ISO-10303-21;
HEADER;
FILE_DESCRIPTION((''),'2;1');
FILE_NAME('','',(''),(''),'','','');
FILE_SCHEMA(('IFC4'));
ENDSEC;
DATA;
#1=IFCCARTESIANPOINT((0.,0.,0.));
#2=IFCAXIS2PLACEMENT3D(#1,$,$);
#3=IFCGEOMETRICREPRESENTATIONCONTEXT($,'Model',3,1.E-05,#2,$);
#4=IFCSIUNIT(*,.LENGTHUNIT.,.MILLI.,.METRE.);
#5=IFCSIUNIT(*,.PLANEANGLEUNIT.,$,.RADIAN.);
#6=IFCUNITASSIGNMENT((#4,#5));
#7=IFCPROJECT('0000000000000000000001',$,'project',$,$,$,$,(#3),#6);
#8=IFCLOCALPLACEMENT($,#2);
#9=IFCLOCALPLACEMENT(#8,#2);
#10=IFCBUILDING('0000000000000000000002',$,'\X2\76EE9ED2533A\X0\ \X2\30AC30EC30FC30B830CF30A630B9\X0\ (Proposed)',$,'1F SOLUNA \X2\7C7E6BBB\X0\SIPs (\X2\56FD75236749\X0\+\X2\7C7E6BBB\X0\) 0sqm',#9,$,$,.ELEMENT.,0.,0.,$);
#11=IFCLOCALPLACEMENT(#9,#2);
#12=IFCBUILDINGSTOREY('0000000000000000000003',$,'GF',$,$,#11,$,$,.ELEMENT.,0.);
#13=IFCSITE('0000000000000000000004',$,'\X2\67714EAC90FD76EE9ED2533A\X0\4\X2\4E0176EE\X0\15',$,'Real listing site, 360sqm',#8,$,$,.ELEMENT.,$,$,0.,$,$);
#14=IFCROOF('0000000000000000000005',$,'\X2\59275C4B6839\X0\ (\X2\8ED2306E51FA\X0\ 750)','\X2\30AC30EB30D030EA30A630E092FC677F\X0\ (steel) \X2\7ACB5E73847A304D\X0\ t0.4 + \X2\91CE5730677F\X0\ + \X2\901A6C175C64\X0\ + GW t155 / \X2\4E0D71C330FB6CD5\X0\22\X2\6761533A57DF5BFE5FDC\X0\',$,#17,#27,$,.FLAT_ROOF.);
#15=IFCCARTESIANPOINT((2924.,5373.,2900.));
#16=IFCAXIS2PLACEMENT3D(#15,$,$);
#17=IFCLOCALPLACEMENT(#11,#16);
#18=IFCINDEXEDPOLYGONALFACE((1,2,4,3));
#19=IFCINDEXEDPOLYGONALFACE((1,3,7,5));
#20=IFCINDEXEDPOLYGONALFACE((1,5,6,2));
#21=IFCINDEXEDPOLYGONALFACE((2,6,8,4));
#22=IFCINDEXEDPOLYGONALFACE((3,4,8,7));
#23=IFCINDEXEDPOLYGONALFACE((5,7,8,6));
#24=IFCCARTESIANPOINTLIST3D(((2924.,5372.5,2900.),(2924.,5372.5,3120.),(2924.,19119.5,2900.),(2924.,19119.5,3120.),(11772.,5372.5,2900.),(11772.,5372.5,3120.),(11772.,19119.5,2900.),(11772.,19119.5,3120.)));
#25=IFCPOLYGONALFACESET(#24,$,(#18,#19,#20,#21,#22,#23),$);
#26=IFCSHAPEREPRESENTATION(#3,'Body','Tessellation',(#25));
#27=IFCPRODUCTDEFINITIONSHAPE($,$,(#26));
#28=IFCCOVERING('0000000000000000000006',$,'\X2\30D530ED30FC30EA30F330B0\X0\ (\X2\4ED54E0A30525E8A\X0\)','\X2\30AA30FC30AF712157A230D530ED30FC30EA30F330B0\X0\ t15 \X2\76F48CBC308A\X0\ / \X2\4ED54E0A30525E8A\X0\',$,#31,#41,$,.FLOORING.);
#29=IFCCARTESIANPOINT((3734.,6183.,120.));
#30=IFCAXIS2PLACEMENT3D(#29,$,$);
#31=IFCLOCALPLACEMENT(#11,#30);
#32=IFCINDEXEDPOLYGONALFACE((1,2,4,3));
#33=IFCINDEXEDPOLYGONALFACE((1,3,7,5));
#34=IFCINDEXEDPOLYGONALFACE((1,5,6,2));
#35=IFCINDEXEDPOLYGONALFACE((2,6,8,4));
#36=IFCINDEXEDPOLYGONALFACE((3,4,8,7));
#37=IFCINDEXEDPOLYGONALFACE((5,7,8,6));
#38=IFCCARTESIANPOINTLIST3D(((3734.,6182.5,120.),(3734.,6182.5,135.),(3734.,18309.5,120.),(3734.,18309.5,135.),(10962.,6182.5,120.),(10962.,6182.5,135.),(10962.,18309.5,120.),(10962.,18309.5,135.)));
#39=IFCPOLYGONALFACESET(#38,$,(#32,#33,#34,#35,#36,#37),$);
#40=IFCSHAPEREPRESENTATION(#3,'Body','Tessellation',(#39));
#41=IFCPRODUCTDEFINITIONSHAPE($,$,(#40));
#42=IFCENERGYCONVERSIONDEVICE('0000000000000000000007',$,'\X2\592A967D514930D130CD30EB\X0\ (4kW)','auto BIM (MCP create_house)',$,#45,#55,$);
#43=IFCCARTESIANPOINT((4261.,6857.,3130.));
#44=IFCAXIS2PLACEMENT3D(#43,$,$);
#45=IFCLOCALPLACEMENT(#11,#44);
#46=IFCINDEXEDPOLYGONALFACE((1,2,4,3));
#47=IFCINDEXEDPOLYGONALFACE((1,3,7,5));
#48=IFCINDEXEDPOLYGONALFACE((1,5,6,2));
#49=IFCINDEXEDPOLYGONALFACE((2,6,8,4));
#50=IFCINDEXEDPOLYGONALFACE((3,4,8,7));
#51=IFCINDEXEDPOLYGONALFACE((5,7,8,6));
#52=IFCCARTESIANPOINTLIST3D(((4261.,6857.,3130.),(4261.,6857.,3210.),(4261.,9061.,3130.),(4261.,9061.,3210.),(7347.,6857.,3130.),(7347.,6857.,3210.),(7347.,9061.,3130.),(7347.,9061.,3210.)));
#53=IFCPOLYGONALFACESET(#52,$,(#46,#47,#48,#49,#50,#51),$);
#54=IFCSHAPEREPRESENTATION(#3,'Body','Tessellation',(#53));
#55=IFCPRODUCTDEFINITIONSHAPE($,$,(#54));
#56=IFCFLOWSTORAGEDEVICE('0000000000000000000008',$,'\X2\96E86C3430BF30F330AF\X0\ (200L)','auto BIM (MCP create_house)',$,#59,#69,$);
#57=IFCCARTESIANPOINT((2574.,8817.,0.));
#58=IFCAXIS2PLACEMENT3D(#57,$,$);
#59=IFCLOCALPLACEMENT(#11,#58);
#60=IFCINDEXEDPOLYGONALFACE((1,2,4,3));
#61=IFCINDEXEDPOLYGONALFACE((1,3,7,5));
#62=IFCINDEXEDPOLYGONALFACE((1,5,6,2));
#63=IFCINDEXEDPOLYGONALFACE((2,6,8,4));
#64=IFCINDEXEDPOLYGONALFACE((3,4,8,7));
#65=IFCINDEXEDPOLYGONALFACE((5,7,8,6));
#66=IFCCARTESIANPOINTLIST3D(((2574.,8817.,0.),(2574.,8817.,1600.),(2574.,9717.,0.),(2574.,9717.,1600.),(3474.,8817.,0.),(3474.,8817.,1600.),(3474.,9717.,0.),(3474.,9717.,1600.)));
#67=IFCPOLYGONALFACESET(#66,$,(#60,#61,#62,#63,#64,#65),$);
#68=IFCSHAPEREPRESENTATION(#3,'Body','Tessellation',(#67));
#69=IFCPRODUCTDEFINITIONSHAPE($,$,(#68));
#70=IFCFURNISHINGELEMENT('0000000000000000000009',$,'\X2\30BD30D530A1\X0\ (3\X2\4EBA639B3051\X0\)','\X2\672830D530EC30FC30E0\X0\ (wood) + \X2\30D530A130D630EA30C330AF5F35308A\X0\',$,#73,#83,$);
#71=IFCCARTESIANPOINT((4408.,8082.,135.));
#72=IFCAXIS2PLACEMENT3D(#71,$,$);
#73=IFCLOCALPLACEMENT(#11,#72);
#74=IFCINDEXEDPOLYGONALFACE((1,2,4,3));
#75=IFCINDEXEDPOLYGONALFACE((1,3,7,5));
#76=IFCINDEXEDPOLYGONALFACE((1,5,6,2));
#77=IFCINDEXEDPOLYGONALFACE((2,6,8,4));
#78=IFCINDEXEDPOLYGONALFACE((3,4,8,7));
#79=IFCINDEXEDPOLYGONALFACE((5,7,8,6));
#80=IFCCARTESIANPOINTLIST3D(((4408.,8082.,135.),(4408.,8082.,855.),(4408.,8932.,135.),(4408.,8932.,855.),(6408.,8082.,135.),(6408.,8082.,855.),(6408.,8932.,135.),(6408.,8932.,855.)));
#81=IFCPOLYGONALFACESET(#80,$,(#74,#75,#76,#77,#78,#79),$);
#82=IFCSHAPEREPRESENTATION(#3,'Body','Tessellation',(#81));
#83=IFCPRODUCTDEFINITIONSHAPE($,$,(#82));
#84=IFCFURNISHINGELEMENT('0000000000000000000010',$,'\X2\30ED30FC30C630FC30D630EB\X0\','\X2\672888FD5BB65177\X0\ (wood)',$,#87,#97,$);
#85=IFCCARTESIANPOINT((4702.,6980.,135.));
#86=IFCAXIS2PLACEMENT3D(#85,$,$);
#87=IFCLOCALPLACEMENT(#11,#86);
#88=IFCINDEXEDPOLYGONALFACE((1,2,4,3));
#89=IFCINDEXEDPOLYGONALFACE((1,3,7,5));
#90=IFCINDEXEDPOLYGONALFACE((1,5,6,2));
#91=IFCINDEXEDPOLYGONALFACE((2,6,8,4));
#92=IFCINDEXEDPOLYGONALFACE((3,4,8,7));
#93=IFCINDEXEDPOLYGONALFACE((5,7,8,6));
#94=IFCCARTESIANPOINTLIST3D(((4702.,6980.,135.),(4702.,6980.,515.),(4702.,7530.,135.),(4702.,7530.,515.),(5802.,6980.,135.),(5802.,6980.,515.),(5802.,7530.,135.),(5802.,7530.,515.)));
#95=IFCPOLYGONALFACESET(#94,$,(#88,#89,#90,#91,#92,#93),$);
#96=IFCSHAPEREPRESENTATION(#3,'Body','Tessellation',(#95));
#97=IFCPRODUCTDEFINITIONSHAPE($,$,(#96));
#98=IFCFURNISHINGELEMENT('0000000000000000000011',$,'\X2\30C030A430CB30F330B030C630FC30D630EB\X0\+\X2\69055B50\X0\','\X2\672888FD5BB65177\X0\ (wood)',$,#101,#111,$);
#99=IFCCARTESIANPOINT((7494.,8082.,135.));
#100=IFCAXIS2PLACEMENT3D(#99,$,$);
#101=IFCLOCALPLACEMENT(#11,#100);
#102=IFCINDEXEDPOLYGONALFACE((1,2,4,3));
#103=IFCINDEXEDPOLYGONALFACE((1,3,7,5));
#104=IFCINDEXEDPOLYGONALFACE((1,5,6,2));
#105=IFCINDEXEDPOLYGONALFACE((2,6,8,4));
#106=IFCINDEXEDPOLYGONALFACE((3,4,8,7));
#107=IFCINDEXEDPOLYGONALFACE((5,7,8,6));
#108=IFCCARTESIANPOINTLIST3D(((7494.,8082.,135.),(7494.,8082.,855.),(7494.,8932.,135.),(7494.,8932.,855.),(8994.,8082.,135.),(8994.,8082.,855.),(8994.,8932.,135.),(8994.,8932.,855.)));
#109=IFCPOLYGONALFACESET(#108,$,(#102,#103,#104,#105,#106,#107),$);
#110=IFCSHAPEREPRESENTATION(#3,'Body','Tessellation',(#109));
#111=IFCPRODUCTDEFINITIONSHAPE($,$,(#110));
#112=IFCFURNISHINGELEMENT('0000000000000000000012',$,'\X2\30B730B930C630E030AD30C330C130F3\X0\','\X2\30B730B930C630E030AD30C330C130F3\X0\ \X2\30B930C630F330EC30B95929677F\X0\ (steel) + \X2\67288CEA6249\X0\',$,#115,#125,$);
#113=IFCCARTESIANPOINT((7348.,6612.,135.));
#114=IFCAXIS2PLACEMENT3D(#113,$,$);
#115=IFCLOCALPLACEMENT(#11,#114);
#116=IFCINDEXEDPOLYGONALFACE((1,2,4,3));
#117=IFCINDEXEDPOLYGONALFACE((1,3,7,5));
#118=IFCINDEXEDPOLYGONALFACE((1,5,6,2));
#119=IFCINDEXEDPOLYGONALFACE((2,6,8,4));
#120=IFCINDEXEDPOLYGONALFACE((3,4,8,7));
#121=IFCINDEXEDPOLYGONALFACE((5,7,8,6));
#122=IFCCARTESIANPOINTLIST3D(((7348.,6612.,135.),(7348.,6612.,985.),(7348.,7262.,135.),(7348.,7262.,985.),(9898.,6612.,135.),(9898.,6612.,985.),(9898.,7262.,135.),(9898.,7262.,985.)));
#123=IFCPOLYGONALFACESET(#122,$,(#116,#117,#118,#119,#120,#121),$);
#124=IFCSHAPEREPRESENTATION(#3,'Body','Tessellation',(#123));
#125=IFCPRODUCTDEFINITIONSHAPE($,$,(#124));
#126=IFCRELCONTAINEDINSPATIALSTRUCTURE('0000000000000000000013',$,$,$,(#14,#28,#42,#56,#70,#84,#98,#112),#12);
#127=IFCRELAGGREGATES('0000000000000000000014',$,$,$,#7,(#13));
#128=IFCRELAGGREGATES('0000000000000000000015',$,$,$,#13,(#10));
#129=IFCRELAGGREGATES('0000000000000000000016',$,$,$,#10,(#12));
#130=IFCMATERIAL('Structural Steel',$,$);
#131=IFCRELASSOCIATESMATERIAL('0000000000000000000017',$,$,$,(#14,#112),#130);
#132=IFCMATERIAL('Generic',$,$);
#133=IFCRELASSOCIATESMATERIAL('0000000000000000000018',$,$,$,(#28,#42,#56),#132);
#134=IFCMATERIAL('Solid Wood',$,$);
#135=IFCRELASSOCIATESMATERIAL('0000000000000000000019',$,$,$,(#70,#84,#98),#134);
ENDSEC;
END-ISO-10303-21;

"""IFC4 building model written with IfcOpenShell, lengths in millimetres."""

from ifc_helpers import new_model, si_unit, frame, frame_2d, origin, place, context, project, spatial, rectangle, extrude, material, element, save


model = new_model("IFC4")

# Units and contexts
model_context = context("Model", 3, precision=1e-05, world=origin())
ifc_project = project(units=[si_unit("LENGTHUNIT", "METRE", prefix="MILLI"), si_unit("PLANEANGLEUNIT", "RADIAN")], contexts=[model_context])

# Site, building, storey
site_placement = place(None, origin())
site = spatial("IfcSite", under=ifc_project, at=site_placement, Name="東京都目黒区4丁目15", ObjectType="Real listing site, 360sqm", CompositionType="ELEMENT", RefElevation=0.0)
building_placement = place(site_placement, origin())
building = spatial("IfcBuilding", under=site, at=building_placement, Name="目黒区 ガレージハウス (Proposed)", ObjectType="1F SOLUNA 籾殻SIPs (国産杉+籾殻) 0sqm", CompositionType="ELEMENT", ElevationOfRefHeight=0.0, ElevationOfTerrain=0.0)
storey_placement = place(building_placement, origin())
storey = spatial("IfcBuildingStorey", under=building, at=storey_placement, Name="GF", CompositionType="ELEMENT", Elevation=0.0)

# Shared definitions
ifc_material_1 = material(Name="Solid Wood")

# Roof
ifc_material_2 = material(Name="Structural Steel")
roof_placement = place(storey_placement, frame((2924.0, 5373.0, 2900.0)))
element("IfcRoof", 1, at=roof_placement, inside=storey, material=ifc_material_2, Name="大屋根 (軒の出 750)", Description="ガルバリウム鋼板 (steel) 立平葺き t0.4 + 野地板 + 通気層 + GW t155 / 不燃・法22条区域対応", PredefinedType="FLAT_ROOF", context=model_context, shape_type="SweptSolid", body=[
    extrude(rectangle(XDim=8848.0, YDim=13747.0, at=frame_2d((4424.0, 6873.0))), frame((2924.0, 5373.0, 2900.0)), (0.0, 0.0, 1.0), 220.0),
])

# Covering
ifc_material_3 = material(Name="Generic")
covering_placement = place(storey_placement, frame((3734.0, 6183.0, 120.0)))
element("IfcCovering", 2, at=covering_placement, inside=storey, material=ifc_material_3, Name="フローリング (仕上げ床)", Description="オーク無垢フローリング t15 直貼り / 仕上げ床", PredefinedType="FLOORING", context=model_context, shape_type="SweptSolid", body=[
    extrude(rectangle(XDim=7228.0, YDim=12127.0, at=frame_2d((3614.0, 6063.0))), frame((3734.0, 6183.0, 120.0)), (0.0, 0.0, 1.0), 15.0),
])

# Energy conversion device
energy_conversion_device_placement = place(storey_placement, frame((4261.0, 6857.0, 3130.0)))
element("IfcEnergyConversionDevice", 3, at=energy_conversion_device_placement, inside=storey, material=ifc_material_3, Name="太陽光パネル (4kW)", Description="auto BIM (MCP create_house)", context=model_context, shape_type="SweptSolid", body=[
    extrude(rectangle(XDim=3086.0, YDim=2204.0, at=frame_2d((1543.0, 1102.0))), frame((4261.0, 6857.0, 3130.0)), (0.0, 0.0, 1.0), 80.0),
])

# Flow storage device
flow_storage_device_placement = place(storey_placement, frame((2574.0, 8817.0, 0.0)))
element("IfcFlowStorageDevice", 4, at=flow_storage_device_placement, inside=storey, material=ifc_material_3, Name="雨水タンク (200L)", Description="auto BIM (MCP create_house)", context=model_context, shape_type="SweptSolid", body=[
    extrude(rectangle(XDim=900.0, YDim=900.0, at=frame_2d((450.0, 450.0))), frame((2574.0, 8817.0, 0.0)), (0.0, 0.0, 1.0), 1600.0),
])

# Furnishing elements
furnishing_1_placement = place(storey_placement, frame((4408.0, 8082.0, 135.0)))
element("IfcFurnishingElement", 5, at=furnishing_1_placement, inside=storey, material=ifc_material_1, Name="ソファ (3人掛け)", Description="木フレーム (wood) + ファブリック張り", context=model_context, shape_type="SweptSolid", body=[
    extrude(rectangle(XDim=2000.0, YDim=850.0, at=frame_2d((1000.0, 425.0))), frame((4408.0, 8082.0, 135.0)), (0.0, 0.0, 1.0), 720.0),
])
furnishing_2_placement = place(storey_placement, frame((4702.0, 6980.0, 135.0)))
element("IfcFurnishingElement", 6, at=furnishing_2_placement, inside=storey, material=ifc_material_1, Name="ローテーブル", Description="木製家具 (wood)", context=model_context, shape_type="SweptSolid", body=[
    extrude(rectangle(XDim=1100.0, YDim=550.0, at=frame_2d((550.0, 275.0))), frame((4702.0, 6980.0, 135.0)), (0.0, 0.0, 1.0), 380.0),
])
furnishing_3_placement = place(storey_placement, frame((7494.0, 8082.0, 135.0)))
element("IfcFurnishingElement", 7, at=furnishing_3_placement, inside=storey, material=ifc_material_1, Name="ダイニングテーブル+椅子", Description="木製家具 (wood)", context=model_context, shape_type="SweptSolid", body=[
    extrude(rectangle(XDim=1500.0, YDim=850.0, at=frame_2d((750.0, 425.0))), frame((7494.0, 8082.0, 135.0)), (0.0, 0.0, 1.0), 720.0),
])
furnishing_4_placement = place(storey_placement, frame((7348.0, 6612.0, 135.0)))
element("IfcFurnishingElement", 8, at=furnishing_4_placement, inside=storey, material=ifc_material_2, Name="システムキッチン", Description="システムキッチン ステンレス天板 (steel) + 木質扉", context=model_context, shape_type="SweptSolid", body=[
    extrude(rectangle(XDim=2550.0, YDim=650.0, at=frame_2d((1275.0, 325.0))), frame((7348.0, 6612.0, 135.0)), (0.0, 0.0, 1.0), 850.0),
])

save(model, "model.ifc")
